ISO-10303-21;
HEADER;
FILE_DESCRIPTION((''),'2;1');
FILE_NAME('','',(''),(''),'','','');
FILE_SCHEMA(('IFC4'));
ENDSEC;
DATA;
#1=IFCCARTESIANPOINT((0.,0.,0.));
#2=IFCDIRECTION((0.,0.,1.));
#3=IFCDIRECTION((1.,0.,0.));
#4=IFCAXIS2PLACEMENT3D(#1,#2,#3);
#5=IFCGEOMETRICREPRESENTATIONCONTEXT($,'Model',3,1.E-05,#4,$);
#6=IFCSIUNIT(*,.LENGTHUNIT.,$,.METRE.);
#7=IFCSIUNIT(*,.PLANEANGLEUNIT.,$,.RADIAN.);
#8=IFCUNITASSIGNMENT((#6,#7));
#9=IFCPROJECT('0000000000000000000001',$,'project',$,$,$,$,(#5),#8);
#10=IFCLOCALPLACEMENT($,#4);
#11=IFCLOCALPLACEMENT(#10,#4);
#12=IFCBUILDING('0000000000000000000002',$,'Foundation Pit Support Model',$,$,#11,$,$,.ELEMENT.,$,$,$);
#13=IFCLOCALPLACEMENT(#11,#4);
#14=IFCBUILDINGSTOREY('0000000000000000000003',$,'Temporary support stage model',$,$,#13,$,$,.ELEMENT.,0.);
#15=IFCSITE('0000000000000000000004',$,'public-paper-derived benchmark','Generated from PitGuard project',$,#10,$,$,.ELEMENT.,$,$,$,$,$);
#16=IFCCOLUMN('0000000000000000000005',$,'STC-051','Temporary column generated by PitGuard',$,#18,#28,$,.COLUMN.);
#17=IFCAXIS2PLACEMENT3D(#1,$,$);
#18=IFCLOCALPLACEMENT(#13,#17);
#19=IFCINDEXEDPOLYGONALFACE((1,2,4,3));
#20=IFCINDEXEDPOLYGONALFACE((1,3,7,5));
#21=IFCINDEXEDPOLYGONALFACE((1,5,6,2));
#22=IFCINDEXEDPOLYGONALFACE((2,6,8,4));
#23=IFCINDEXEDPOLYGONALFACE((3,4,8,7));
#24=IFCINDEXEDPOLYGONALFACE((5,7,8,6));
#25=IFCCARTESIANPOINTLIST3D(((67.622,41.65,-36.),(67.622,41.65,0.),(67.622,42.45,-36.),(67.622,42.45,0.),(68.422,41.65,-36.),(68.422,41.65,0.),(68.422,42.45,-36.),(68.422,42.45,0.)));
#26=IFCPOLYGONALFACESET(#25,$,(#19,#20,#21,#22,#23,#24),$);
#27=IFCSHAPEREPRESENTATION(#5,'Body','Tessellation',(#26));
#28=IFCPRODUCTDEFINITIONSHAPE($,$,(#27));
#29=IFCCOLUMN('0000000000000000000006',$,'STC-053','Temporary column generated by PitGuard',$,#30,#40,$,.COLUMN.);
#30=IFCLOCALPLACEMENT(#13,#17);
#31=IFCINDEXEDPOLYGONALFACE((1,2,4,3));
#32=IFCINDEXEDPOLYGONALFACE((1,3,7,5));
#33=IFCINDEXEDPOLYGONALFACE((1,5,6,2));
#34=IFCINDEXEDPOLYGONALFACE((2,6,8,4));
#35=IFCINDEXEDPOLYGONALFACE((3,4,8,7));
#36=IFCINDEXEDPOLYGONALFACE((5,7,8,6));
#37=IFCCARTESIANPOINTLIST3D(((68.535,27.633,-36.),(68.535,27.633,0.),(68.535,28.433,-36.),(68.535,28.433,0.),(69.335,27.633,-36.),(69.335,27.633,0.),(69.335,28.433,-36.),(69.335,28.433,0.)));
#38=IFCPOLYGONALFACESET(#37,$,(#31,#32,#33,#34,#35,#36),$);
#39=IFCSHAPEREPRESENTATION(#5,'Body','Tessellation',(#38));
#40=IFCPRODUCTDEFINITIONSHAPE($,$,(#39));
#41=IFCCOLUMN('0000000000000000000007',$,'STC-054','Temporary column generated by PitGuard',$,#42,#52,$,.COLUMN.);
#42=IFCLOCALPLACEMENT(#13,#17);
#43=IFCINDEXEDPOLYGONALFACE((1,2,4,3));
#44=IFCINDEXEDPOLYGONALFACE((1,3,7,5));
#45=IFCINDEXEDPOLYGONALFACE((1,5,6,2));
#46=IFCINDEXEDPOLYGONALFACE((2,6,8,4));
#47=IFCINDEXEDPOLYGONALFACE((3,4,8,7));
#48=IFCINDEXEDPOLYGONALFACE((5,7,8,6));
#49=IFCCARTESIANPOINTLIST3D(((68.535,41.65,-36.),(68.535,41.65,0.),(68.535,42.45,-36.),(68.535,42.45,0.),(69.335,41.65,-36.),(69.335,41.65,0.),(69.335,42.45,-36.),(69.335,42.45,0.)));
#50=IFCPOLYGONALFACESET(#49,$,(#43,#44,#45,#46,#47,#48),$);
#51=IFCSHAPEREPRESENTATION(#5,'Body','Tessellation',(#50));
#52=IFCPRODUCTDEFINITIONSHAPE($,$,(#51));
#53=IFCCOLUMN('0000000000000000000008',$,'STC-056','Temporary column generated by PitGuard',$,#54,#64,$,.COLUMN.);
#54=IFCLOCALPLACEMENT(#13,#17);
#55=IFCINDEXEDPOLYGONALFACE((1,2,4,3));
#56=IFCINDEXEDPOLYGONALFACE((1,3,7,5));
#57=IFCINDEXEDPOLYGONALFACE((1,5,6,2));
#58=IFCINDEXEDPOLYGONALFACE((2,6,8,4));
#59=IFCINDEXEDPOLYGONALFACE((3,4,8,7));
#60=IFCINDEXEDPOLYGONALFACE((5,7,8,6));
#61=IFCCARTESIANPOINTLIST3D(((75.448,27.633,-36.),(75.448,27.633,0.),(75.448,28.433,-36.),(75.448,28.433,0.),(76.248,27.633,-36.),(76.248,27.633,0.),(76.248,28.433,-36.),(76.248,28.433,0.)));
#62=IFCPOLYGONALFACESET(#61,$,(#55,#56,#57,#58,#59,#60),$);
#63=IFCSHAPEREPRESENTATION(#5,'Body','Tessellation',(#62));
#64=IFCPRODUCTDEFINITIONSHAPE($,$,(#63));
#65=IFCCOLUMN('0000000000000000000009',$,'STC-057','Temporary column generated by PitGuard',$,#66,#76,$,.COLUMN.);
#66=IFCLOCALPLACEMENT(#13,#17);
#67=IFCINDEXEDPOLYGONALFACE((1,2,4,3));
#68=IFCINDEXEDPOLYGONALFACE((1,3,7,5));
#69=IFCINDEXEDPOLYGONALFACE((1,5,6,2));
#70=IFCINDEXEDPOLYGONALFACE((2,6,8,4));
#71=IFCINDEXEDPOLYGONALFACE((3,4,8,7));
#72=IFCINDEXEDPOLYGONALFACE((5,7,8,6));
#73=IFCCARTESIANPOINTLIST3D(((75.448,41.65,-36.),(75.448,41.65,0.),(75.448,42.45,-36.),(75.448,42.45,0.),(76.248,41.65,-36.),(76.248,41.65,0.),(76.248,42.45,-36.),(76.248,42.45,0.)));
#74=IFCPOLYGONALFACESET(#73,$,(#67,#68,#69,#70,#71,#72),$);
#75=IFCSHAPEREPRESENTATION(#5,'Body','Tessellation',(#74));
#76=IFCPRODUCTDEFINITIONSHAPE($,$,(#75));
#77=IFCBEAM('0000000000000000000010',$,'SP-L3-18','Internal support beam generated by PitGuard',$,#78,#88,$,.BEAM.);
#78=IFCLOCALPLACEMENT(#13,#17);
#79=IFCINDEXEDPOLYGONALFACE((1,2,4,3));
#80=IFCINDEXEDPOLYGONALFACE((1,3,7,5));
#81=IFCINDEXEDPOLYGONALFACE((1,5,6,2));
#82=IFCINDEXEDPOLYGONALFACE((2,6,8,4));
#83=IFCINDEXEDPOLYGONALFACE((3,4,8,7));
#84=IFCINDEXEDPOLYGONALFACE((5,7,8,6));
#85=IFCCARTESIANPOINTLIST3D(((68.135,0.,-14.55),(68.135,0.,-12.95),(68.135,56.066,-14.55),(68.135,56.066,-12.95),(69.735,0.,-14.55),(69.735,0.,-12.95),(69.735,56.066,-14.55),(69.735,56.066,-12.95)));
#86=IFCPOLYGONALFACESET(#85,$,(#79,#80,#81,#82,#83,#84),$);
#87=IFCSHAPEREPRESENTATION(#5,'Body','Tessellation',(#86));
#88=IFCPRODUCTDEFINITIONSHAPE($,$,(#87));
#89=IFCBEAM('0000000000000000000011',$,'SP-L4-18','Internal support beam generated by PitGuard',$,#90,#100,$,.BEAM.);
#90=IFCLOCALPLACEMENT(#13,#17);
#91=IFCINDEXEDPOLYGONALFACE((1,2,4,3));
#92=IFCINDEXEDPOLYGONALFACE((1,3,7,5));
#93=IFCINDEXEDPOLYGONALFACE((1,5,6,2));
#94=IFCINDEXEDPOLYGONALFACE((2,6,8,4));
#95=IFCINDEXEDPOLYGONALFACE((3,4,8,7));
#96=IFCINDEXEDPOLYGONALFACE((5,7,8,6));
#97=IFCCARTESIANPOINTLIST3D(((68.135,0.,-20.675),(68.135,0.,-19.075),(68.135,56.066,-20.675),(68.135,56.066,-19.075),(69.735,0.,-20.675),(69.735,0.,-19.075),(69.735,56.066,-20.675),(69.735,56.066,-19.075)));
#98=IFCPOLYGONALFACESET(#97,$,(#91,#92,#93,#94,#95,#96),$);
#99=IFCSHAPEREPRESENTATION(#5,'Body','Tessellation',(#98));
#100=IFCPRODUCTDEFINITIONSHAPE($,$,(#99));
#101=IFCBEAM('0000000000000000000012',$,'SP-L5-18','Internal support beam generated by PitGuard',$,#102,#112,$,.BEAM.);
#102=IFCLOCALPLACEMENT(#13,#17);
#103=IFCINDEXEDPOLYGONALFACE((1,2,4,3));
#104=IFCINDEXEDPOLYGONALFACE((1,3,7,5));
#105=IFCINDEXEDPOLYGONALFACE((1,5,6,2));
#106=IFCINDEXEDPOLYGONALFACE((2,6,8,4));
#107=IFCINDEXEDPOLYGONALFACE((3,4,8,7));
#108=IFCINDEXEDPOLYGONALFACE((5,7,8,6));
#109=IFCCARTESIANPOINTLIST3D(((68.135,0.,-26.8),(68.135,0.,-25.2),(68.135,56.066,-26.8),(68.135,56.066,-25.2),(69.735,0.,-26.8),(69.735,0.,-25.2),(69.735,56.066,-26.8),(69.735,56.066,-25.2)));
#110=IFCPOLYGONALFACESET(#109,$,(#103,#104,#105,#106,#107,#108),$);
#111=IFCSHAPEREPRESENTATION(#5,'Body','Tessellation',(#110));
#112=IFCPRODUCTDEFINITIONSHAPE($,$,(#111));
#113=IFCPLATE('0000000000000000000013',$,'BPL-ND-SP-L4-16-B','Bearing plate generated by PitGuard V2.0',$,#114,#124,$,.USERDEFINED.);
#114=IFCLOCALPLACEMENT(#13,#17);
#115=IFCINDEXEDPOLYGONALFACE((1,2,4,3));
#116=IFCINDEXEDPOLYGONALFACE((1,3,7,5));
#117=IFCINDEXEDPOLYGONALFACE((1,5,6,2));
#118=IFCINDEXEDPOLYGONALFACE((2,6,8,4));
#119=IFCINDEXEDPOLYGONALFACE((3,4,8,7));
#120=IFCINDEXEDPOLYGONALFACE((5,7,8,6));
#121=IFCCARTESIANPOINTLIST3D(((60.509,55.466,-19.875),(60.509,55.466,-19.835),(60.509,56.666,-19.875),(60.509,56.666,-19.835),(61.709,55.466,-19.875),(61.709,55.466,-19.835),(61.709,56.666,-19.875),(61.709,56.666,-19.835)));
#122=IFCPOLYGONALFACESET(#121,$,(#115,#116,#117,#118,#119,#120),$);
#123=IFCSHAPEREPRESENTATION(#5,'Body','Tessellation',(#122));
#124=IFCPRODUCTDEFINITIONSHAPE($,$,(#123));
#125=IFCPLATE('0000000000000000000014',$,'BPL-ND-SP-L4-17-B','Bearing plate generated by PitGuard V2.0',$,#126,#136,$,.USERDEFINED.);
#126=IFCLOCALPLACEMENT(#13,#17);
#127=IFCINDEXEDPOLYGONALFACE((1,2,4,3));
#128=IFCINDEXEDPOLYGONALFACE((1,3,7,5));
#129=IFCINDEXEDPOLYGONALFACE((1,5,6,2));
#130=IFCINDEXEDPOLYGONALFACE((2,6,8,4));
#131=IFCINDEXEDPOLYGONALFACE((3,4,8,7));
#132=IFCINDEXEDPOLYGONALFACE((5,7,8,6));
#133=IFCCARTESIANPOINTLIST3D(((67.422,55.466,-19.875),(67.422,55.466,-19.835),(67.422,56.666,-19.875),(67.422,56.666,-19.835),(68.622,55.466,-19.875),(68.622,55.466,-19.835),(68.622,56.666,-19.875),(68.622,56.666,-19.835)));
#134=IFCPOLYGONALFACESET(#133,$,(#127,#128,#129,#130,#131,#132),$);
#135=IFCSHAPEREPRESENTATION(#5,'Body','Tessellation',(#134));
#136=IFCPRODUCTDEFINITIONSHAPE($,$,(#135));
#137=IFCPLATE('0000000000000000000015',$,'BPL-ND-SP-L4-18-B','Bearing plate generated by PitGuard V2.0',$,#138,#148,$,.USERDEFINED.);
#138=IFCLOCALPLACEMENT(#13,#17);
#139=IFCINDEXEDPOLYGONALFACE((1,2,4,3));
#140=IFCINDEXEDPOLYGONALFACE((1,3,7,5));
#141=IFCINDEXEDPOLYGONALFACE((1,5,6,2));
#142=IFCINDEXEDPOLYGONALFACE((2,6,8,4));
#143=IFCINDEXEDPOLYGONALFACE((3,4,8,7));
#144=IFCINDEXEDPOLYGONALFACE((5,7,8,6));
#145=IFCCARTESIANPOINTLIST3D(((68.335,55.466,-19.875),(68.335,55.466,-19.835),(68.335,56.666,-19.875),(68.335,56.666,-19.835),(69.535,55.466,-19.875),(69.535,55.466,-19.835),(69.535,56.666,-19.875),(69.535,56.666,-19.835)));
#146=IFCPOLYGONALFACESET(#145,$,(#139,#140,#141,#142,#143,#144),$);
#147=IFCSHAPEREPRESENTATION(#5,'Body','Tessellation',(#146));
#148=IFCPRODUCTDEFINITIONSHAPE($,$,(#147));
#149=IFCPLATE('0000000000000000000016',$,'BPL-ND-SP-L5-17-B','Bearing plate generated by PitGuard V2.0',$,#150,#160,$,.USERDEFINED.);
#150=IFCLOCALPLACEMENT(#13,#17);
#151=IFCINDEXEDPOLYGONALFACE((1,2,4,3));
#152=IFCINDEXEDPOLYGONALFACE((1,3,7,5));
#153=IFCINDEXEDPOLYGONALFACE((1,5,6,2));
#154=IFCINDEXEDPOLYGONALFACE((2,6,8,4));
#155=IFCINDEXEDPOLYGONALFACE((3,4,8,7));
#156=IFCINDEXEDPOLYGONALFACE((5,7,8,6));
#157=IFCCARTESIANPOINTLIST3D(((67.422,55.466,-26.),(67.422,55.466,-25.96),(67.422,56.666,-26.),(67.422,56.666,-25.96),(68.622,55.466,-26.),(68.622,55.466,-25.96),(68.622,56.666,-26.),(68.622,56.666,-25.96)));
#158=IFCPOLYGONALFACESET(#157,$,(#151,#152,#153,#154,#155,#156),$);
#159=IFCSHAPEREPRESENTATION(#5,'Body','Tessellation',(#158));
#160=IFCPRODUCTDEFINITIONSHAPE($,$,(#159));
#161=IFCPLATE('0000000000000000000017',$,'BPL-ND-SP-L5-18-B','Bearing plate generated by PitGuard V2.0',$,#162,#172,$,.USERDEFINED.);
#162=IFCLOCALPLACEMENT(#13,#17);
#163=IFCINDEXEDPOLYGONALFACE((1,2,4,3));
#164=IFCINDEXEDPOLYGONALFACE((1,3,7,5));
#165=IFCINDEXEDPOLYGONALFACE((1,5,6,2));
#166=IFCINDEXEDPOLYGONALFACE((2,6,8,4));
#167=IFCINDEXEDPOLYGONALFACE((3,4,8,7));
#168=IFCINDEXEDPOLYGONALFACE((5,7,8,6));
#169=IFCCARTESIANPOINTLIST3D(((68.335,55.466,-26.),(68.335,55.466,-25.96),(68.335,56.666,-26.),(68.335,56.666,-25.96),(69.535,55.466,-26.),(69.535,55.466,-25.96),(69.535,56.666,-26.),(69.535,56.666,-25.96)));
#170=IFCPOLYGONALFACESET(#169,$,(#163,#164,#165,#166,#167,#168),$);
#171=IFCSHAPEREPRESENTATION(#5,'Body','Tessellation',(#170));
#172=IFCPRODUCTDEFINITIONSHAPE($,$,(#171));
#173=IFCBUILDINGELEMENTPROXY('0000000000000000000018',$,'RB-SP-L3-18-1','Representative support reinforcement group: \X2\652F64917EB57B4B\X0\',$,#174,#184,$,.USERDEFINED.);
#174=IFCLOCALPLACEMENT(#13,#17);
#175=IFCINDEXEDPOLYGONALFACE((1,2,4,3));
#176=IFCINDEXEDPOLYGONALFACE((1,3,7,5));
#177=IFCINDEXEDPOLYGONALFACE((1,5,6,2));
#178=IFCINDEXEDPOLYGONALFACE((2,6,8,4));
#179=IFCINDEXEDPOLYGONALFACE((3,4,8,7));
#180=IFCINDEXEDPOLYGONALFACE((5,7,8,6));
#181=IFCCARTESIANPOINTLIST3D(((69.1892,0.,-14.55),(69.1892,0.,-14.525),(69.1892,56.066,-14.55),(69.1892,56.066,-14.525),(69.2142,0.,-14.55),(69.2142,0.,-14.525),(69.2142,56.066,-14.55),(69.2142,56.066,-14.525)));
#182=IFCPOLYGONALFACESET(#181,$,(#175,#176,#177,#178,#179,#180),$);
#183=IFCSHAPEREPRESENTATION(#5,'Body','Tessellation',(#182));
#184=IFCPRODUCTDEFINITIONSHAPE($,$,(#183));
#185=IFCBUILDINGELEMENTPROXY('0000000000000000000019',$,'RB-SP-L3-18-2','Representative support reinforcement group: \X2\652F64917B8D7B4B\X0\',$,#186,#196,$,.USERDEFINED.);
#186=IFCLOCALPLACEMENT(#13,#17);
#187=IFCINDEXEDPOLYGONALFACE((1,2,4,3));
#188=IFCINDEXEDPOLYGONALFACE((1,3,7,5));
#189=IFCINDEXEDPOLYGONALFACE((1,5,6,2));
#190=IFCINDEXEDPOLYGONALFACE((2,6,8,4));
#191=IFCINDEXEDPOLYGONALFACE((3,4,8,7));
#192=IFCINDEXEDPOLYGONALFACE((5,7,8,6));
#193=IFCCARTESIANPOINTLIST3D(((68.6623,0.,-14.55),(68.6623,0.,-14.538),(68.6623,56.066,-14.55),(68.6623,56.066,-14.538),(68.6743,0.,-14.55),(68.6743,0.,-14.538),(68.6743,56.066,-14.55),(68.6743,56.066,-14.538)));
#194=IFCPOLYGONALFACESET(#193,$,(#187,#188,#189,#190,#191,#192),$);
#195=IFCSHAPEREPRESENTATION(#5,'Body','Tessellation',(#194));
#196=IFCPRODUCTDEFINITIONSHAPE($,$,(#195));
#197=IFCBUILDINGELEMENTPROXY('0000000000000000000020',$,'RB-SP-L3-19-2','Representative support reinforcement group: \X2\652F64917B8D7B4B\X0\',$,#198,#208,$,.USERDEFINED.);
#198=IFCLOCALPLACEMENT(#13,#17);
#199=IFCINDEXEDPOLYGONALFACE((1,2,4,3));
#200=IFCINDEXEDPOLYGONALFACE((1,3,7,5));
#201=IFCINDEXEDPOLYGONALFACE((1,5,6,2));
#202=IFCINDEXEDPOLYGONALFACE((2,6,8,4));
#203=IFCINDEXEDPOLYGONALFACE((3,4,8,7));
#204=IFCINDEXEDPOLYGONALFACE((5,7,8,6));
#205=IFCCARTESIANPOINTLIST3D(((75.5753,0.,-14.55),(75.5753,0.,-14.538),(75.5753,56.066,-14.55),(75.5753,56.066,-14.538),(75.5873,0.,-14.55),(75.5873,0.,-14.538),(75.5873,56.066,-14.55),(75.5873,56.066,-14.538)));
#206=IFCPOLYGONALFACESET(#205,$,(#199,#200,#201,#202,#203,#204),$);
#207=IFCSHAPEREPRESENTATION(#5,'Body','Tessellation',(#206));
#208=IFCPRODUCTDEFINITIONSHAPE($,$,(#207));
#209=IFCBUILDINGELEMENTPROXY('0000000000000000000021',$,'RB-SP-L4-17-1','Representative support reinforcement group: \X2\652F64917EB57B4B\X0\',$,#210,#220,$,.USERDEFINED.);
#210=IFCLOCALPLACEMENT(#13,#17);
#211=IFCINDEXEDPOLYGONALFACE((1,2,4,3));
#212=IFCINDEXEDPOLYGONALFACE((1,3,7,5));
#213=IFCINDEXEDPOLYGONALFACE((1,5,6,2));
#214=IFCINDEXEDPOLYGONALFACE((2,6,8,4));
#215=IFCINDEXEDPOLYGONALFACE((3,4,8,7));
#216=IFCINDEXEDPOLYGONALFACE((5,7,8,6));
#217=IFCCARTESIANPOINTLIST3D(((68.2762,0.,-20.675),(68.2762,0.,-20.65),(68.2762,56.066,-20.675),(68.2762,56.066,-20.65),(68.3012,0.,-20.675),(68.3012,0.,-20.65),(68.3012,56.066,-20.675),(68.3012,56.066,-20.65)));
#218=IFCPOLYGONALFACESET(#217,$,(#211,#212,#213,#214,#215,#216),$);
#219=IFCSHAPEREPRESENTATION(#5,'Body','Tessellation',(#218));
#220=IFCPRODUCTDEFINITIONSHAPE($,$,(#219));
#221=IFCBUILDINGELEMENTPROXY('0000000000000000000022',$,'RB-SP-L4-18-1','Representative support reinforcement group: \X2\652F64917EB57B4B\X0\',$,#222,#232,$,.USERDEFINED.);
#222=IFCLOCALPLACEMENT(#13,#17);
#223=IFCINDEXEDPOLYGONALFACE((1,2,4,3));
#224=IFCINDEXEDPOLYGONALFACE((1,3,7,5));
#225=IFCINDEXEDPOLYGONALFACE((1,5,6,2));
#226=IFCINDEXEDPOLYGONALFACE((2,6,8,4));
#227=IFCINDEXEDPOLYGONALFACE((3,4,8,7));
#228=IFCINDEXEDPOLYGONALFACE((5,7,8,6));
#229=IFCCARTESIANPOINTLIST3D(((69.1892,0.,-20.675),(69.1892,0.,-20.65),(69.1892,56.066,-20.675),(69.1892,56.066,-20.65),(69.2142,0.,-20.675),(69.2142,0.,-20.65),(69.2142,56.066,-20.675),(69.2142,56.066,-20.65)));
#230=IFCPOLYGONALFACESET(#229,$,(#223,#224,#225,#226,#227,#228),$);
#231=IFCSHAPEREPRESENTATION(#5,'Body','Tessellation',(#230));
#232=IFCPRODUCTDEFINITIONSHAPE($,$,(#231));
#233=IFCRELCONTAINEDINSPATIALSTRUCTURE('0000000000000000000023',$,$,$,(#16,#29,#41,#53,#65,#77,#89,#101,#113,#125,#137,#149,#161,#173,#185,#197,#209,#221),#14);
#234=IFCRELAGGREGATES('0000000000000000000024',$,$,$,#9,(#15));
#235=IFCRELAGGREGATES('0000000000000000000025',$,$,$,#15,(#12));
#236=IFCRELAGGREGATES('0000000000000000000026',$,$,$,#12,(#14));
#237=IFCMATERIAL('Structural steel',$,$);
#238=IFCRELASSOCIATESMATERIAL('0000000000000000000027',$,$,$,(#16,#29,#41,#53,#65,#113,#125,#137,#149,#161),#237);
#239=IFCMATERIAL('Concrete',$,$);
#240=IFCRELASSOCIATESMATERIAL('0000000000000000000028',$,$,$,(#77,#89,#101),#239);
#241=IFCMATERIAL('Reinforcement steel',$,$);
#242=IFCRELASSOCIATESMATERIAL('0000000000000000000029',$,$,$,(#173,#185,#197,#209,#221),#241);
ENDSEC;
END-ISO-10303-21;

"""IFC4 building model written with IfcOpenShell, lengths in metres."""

from ifc_helpers import new_model, si_unit, frame, origin_with_axes, origin_2d, place, context, project, spatial, rectangle, extrude, material, element, save


model = new_model("IFC4")

# Units and contexts
model_context = context("Model", 3, precision=1e-05, world=origin_with_axes())
ifc_project = project(units=[si_unit("LENGTHUNIT", "METRE"), si_unit("PLANEANGLEUNIT", "RADIAN")], contexts=[model_context])

# Site, building, storey
site_placement = place(None, origin_with_axes())
site = spatial("IfcSite", under=ifc_project, at=site_placement, Name="public-paper-derived benchmark", Description="Generated from PitGuard project", CompositionType="ELEMENT")
building_placement = place(site_placement, origin_with_axes())
building = spatial("IfcBuilding", under=site, at=building_placement, Name="Foundation Pit Support Model", CompositionType="ELEMENT")
storey_placement = place(building_placement, origin_with_axes())
storey = spatial("IfcBuildingStorey", under=building, at=storey_placement, Name="Temporary support stage model", CompositionType="ELEMENT", Elevation=0.0)

# Columns
ifc_material_1 = material(Name="Structural steel")
for number, where, z_axis, x_axis, name in (
    (1, (68.022, 42.05, -36.0), (0.0, 0.0, 1.0), (1.0, 0.0, 0.0), "STC-051"),
    (2, (68.935, 28.033, -36.0), (0.0, 0.0, 1.0), (1.0, 0.0, 0.0), "STC-053"),
    (3, (68.935, 42.05, -36.0), (0.0, 0.0, 1.0), (1.0, 0.0, 0.0), "STC-054"),
    (4, (75.848, 28.033, -36.0), (0.0, 0.0, 1.0), (1.0, 0.0, 0.0), "STC-056"),
    (5, (75.848, 42.05, -36.0), (0.0, 0.0, 1.0), (1.0, 0.0, 0.0), "STC-057"),
):
    element("IfcColumn", number, at=place(storey_placement, frame(where, z_axis=z_axis, x_axis=x_axis)), inside=storey, material=ifc_material_1, Name=name, Description="Temporary column generated by PitGuard", PredefinedType="COLUMN", context=model_context, shape_type="SweptSolid", body=[
        extrude(rectangle(XDim=0.8, YDim=0.8, at=origin_2d()), origin_with_axes(), (0.0, 0.0, 1.0), 36.0),
    ])

# Beams
ifc_material_2 = material(Name="Concrete")
for number, where, z_axis, x_axis, name in (
    (6, (68.935, 28.033, -14.55), (0.0, 0.0, 1.0), (0.0, 1.0, 0.0), "SP-L3-18"),
    (7, (68.935, 28.033, -20.675), (0.0, 0.0, 1.0), (0.0, 1.0, 0.0), "SP-L4-18"),
    (8, (68.935, 28.033, -26.8), (0.0, 0.0, 1.0), (0.0, 1.0, 0.0), "SP-L5-18"),
):
    element("IfcBeam", number, at=place(storey_placement, frame(where, z_axis=z_axis, x_axis=x_axis)), inside=storey, material=ifc_material_2, Name=name, Description="Internal support beam generated by PitGuard", PredefinedType="BEAM", context=model_context, shape_type="SweptSolid", body=[
        extrude(rectangle(XDim=56.066, YDim=1.6, at=origin_2d()), origin_with_axes(), (0.0, 0.0, 1.0), 1.6),
    ])

# Plates
for number, where, z_axis, x_axis, name in (
    (9, (61.109, 56.066, -19.875), (0.0, 0.0, 1.0), (1.0, 0.0, 0.0), "BPL-ND-SP-L4-16-B"),
    (10, (68.022, 56.066, -19.875), (0.0, 0.0, 1.0), (1.0, 0.0, 0.0), "BPL-ND-SP-L4-17-B"),
    (11, (68.935, 56.066, -19.875), (0.0, 0.0, 1.0), (1.0, 0.0, 0.0), "BPL-ND-SP-L4-18-B"),
    (12, (68.022, 56.066, -26.0), (0.0, 0.0, 1.0), (1.0, 0.0, 0.0), "BPL-ND-SP-L5-17-B"),
    (13, (68.935, 56.066, -26.0), (0.0, 0.0, 1.0), (1.0, 0.0, 0.0), "BPL-ND-SP-L5-18-B"),
):
    element("IfcPlate", number, at=place(storey_placement, frame(where, z_axis=z_axis, x_axis=x_axis)), inside=storey, material=ifc_material_1, Name=name, Description="Bearing plate generated by PitGuard V2.0", PredefinedType="USERDEFINED", context=model_context, shape_type="SweptSolid", body=[
        extrude(rectangle(XDim=1.2, YDim=1.2, at=origin_2d()), origin_with_axes(), (0.0, 0.0, 1.0), 0.04),
    ])

# Building element proxies
ifc_material_3 = material(Name="Reinforcement steel")
proxy_1_placement = place(storey_placement, frame((69.2017, 28.033, -14.55), z_axis=(0.0, 0.0, 1.0), x_axis=(0.0, 1.0, 0.0)))
element("IfcBuildingElementProxy", 14, at=proxy_1_placement, inside=storey, material=ifc_material_3, Name="RB-SP-L3-18-1", Description="Representative support reinforcement group: 支撑纵筋", PredefinedType="USERDEFINED", context=model_context, shape_type="SweptSolid", body=[
    extrude(rectangle(XDim=56.066, YDim=0.025, at=origin_2d()), origin_with_axes(), (0.0, 0.0, 1.0), 0.025),
])
for number, where, z_axis, x_axis, name in (
    (15, (68.6683, 28.033, -14.55), (0.0, 0.0, 1.0), (0.0, 1.0, 0.0), "RB-SP-L3-18-2"),
    (16, (75.5813, 28.033, -14.55), (0.0, 0.0, 1.0), (0.0, 1.0, 0.0), "RB-SP-L3-19-2"),
):
    element("IfcBuildingElementProxy", number, at=place(storey_placement, frame(where, z_axis=z_axis, x_axis=x_axis)), inside=storey, material=ifc_material_3, Name=name, Description="Representative support reinforcement group: 支撑箍筋", PredefinedType="USERDEFINED", context=model_context, shape_type="SweptSolid", body=[
        extrude(rectangle(XDim=56.066, YDim=0.012, at=origin_2d()), origin_with_axes(), (0.0, 0.0, 1.0), 0.012),
    ])
for number, where, z_axis, x_axis, name in (
    (17, (68.2887, 28.033, -20.675), (0.0, 0.0, 1.0), (0.0, 1.0, 0.0), "RB-SP-L4-17-1"),
    (18, (69.2017, 28.033, -20.675), (0.0, 0.0, 1.0), (0.0, 1.0, 0.0), "RB-SP-L4-18-1"),
):
    element("IfcBuildingElementProxy", number, at=place(storey_placement, frame(where, z_axis=z_axis, x_axis=x_axis)), inside=storey, material=ifc_material_3, Name=name, Description="Representative support reinforcement group: 支撑纵筋", PredefinedType="USERDEFINED", context=model_context, shape_type="SweptSolid", body=[
        extrude(rectangle(XDim=56.066, YDim=0.025, at=origin_2d()), origin_with_axes(), (0.0, 0.0, 1.0), 0.025),
    ])

save(model, "model.ifc")
